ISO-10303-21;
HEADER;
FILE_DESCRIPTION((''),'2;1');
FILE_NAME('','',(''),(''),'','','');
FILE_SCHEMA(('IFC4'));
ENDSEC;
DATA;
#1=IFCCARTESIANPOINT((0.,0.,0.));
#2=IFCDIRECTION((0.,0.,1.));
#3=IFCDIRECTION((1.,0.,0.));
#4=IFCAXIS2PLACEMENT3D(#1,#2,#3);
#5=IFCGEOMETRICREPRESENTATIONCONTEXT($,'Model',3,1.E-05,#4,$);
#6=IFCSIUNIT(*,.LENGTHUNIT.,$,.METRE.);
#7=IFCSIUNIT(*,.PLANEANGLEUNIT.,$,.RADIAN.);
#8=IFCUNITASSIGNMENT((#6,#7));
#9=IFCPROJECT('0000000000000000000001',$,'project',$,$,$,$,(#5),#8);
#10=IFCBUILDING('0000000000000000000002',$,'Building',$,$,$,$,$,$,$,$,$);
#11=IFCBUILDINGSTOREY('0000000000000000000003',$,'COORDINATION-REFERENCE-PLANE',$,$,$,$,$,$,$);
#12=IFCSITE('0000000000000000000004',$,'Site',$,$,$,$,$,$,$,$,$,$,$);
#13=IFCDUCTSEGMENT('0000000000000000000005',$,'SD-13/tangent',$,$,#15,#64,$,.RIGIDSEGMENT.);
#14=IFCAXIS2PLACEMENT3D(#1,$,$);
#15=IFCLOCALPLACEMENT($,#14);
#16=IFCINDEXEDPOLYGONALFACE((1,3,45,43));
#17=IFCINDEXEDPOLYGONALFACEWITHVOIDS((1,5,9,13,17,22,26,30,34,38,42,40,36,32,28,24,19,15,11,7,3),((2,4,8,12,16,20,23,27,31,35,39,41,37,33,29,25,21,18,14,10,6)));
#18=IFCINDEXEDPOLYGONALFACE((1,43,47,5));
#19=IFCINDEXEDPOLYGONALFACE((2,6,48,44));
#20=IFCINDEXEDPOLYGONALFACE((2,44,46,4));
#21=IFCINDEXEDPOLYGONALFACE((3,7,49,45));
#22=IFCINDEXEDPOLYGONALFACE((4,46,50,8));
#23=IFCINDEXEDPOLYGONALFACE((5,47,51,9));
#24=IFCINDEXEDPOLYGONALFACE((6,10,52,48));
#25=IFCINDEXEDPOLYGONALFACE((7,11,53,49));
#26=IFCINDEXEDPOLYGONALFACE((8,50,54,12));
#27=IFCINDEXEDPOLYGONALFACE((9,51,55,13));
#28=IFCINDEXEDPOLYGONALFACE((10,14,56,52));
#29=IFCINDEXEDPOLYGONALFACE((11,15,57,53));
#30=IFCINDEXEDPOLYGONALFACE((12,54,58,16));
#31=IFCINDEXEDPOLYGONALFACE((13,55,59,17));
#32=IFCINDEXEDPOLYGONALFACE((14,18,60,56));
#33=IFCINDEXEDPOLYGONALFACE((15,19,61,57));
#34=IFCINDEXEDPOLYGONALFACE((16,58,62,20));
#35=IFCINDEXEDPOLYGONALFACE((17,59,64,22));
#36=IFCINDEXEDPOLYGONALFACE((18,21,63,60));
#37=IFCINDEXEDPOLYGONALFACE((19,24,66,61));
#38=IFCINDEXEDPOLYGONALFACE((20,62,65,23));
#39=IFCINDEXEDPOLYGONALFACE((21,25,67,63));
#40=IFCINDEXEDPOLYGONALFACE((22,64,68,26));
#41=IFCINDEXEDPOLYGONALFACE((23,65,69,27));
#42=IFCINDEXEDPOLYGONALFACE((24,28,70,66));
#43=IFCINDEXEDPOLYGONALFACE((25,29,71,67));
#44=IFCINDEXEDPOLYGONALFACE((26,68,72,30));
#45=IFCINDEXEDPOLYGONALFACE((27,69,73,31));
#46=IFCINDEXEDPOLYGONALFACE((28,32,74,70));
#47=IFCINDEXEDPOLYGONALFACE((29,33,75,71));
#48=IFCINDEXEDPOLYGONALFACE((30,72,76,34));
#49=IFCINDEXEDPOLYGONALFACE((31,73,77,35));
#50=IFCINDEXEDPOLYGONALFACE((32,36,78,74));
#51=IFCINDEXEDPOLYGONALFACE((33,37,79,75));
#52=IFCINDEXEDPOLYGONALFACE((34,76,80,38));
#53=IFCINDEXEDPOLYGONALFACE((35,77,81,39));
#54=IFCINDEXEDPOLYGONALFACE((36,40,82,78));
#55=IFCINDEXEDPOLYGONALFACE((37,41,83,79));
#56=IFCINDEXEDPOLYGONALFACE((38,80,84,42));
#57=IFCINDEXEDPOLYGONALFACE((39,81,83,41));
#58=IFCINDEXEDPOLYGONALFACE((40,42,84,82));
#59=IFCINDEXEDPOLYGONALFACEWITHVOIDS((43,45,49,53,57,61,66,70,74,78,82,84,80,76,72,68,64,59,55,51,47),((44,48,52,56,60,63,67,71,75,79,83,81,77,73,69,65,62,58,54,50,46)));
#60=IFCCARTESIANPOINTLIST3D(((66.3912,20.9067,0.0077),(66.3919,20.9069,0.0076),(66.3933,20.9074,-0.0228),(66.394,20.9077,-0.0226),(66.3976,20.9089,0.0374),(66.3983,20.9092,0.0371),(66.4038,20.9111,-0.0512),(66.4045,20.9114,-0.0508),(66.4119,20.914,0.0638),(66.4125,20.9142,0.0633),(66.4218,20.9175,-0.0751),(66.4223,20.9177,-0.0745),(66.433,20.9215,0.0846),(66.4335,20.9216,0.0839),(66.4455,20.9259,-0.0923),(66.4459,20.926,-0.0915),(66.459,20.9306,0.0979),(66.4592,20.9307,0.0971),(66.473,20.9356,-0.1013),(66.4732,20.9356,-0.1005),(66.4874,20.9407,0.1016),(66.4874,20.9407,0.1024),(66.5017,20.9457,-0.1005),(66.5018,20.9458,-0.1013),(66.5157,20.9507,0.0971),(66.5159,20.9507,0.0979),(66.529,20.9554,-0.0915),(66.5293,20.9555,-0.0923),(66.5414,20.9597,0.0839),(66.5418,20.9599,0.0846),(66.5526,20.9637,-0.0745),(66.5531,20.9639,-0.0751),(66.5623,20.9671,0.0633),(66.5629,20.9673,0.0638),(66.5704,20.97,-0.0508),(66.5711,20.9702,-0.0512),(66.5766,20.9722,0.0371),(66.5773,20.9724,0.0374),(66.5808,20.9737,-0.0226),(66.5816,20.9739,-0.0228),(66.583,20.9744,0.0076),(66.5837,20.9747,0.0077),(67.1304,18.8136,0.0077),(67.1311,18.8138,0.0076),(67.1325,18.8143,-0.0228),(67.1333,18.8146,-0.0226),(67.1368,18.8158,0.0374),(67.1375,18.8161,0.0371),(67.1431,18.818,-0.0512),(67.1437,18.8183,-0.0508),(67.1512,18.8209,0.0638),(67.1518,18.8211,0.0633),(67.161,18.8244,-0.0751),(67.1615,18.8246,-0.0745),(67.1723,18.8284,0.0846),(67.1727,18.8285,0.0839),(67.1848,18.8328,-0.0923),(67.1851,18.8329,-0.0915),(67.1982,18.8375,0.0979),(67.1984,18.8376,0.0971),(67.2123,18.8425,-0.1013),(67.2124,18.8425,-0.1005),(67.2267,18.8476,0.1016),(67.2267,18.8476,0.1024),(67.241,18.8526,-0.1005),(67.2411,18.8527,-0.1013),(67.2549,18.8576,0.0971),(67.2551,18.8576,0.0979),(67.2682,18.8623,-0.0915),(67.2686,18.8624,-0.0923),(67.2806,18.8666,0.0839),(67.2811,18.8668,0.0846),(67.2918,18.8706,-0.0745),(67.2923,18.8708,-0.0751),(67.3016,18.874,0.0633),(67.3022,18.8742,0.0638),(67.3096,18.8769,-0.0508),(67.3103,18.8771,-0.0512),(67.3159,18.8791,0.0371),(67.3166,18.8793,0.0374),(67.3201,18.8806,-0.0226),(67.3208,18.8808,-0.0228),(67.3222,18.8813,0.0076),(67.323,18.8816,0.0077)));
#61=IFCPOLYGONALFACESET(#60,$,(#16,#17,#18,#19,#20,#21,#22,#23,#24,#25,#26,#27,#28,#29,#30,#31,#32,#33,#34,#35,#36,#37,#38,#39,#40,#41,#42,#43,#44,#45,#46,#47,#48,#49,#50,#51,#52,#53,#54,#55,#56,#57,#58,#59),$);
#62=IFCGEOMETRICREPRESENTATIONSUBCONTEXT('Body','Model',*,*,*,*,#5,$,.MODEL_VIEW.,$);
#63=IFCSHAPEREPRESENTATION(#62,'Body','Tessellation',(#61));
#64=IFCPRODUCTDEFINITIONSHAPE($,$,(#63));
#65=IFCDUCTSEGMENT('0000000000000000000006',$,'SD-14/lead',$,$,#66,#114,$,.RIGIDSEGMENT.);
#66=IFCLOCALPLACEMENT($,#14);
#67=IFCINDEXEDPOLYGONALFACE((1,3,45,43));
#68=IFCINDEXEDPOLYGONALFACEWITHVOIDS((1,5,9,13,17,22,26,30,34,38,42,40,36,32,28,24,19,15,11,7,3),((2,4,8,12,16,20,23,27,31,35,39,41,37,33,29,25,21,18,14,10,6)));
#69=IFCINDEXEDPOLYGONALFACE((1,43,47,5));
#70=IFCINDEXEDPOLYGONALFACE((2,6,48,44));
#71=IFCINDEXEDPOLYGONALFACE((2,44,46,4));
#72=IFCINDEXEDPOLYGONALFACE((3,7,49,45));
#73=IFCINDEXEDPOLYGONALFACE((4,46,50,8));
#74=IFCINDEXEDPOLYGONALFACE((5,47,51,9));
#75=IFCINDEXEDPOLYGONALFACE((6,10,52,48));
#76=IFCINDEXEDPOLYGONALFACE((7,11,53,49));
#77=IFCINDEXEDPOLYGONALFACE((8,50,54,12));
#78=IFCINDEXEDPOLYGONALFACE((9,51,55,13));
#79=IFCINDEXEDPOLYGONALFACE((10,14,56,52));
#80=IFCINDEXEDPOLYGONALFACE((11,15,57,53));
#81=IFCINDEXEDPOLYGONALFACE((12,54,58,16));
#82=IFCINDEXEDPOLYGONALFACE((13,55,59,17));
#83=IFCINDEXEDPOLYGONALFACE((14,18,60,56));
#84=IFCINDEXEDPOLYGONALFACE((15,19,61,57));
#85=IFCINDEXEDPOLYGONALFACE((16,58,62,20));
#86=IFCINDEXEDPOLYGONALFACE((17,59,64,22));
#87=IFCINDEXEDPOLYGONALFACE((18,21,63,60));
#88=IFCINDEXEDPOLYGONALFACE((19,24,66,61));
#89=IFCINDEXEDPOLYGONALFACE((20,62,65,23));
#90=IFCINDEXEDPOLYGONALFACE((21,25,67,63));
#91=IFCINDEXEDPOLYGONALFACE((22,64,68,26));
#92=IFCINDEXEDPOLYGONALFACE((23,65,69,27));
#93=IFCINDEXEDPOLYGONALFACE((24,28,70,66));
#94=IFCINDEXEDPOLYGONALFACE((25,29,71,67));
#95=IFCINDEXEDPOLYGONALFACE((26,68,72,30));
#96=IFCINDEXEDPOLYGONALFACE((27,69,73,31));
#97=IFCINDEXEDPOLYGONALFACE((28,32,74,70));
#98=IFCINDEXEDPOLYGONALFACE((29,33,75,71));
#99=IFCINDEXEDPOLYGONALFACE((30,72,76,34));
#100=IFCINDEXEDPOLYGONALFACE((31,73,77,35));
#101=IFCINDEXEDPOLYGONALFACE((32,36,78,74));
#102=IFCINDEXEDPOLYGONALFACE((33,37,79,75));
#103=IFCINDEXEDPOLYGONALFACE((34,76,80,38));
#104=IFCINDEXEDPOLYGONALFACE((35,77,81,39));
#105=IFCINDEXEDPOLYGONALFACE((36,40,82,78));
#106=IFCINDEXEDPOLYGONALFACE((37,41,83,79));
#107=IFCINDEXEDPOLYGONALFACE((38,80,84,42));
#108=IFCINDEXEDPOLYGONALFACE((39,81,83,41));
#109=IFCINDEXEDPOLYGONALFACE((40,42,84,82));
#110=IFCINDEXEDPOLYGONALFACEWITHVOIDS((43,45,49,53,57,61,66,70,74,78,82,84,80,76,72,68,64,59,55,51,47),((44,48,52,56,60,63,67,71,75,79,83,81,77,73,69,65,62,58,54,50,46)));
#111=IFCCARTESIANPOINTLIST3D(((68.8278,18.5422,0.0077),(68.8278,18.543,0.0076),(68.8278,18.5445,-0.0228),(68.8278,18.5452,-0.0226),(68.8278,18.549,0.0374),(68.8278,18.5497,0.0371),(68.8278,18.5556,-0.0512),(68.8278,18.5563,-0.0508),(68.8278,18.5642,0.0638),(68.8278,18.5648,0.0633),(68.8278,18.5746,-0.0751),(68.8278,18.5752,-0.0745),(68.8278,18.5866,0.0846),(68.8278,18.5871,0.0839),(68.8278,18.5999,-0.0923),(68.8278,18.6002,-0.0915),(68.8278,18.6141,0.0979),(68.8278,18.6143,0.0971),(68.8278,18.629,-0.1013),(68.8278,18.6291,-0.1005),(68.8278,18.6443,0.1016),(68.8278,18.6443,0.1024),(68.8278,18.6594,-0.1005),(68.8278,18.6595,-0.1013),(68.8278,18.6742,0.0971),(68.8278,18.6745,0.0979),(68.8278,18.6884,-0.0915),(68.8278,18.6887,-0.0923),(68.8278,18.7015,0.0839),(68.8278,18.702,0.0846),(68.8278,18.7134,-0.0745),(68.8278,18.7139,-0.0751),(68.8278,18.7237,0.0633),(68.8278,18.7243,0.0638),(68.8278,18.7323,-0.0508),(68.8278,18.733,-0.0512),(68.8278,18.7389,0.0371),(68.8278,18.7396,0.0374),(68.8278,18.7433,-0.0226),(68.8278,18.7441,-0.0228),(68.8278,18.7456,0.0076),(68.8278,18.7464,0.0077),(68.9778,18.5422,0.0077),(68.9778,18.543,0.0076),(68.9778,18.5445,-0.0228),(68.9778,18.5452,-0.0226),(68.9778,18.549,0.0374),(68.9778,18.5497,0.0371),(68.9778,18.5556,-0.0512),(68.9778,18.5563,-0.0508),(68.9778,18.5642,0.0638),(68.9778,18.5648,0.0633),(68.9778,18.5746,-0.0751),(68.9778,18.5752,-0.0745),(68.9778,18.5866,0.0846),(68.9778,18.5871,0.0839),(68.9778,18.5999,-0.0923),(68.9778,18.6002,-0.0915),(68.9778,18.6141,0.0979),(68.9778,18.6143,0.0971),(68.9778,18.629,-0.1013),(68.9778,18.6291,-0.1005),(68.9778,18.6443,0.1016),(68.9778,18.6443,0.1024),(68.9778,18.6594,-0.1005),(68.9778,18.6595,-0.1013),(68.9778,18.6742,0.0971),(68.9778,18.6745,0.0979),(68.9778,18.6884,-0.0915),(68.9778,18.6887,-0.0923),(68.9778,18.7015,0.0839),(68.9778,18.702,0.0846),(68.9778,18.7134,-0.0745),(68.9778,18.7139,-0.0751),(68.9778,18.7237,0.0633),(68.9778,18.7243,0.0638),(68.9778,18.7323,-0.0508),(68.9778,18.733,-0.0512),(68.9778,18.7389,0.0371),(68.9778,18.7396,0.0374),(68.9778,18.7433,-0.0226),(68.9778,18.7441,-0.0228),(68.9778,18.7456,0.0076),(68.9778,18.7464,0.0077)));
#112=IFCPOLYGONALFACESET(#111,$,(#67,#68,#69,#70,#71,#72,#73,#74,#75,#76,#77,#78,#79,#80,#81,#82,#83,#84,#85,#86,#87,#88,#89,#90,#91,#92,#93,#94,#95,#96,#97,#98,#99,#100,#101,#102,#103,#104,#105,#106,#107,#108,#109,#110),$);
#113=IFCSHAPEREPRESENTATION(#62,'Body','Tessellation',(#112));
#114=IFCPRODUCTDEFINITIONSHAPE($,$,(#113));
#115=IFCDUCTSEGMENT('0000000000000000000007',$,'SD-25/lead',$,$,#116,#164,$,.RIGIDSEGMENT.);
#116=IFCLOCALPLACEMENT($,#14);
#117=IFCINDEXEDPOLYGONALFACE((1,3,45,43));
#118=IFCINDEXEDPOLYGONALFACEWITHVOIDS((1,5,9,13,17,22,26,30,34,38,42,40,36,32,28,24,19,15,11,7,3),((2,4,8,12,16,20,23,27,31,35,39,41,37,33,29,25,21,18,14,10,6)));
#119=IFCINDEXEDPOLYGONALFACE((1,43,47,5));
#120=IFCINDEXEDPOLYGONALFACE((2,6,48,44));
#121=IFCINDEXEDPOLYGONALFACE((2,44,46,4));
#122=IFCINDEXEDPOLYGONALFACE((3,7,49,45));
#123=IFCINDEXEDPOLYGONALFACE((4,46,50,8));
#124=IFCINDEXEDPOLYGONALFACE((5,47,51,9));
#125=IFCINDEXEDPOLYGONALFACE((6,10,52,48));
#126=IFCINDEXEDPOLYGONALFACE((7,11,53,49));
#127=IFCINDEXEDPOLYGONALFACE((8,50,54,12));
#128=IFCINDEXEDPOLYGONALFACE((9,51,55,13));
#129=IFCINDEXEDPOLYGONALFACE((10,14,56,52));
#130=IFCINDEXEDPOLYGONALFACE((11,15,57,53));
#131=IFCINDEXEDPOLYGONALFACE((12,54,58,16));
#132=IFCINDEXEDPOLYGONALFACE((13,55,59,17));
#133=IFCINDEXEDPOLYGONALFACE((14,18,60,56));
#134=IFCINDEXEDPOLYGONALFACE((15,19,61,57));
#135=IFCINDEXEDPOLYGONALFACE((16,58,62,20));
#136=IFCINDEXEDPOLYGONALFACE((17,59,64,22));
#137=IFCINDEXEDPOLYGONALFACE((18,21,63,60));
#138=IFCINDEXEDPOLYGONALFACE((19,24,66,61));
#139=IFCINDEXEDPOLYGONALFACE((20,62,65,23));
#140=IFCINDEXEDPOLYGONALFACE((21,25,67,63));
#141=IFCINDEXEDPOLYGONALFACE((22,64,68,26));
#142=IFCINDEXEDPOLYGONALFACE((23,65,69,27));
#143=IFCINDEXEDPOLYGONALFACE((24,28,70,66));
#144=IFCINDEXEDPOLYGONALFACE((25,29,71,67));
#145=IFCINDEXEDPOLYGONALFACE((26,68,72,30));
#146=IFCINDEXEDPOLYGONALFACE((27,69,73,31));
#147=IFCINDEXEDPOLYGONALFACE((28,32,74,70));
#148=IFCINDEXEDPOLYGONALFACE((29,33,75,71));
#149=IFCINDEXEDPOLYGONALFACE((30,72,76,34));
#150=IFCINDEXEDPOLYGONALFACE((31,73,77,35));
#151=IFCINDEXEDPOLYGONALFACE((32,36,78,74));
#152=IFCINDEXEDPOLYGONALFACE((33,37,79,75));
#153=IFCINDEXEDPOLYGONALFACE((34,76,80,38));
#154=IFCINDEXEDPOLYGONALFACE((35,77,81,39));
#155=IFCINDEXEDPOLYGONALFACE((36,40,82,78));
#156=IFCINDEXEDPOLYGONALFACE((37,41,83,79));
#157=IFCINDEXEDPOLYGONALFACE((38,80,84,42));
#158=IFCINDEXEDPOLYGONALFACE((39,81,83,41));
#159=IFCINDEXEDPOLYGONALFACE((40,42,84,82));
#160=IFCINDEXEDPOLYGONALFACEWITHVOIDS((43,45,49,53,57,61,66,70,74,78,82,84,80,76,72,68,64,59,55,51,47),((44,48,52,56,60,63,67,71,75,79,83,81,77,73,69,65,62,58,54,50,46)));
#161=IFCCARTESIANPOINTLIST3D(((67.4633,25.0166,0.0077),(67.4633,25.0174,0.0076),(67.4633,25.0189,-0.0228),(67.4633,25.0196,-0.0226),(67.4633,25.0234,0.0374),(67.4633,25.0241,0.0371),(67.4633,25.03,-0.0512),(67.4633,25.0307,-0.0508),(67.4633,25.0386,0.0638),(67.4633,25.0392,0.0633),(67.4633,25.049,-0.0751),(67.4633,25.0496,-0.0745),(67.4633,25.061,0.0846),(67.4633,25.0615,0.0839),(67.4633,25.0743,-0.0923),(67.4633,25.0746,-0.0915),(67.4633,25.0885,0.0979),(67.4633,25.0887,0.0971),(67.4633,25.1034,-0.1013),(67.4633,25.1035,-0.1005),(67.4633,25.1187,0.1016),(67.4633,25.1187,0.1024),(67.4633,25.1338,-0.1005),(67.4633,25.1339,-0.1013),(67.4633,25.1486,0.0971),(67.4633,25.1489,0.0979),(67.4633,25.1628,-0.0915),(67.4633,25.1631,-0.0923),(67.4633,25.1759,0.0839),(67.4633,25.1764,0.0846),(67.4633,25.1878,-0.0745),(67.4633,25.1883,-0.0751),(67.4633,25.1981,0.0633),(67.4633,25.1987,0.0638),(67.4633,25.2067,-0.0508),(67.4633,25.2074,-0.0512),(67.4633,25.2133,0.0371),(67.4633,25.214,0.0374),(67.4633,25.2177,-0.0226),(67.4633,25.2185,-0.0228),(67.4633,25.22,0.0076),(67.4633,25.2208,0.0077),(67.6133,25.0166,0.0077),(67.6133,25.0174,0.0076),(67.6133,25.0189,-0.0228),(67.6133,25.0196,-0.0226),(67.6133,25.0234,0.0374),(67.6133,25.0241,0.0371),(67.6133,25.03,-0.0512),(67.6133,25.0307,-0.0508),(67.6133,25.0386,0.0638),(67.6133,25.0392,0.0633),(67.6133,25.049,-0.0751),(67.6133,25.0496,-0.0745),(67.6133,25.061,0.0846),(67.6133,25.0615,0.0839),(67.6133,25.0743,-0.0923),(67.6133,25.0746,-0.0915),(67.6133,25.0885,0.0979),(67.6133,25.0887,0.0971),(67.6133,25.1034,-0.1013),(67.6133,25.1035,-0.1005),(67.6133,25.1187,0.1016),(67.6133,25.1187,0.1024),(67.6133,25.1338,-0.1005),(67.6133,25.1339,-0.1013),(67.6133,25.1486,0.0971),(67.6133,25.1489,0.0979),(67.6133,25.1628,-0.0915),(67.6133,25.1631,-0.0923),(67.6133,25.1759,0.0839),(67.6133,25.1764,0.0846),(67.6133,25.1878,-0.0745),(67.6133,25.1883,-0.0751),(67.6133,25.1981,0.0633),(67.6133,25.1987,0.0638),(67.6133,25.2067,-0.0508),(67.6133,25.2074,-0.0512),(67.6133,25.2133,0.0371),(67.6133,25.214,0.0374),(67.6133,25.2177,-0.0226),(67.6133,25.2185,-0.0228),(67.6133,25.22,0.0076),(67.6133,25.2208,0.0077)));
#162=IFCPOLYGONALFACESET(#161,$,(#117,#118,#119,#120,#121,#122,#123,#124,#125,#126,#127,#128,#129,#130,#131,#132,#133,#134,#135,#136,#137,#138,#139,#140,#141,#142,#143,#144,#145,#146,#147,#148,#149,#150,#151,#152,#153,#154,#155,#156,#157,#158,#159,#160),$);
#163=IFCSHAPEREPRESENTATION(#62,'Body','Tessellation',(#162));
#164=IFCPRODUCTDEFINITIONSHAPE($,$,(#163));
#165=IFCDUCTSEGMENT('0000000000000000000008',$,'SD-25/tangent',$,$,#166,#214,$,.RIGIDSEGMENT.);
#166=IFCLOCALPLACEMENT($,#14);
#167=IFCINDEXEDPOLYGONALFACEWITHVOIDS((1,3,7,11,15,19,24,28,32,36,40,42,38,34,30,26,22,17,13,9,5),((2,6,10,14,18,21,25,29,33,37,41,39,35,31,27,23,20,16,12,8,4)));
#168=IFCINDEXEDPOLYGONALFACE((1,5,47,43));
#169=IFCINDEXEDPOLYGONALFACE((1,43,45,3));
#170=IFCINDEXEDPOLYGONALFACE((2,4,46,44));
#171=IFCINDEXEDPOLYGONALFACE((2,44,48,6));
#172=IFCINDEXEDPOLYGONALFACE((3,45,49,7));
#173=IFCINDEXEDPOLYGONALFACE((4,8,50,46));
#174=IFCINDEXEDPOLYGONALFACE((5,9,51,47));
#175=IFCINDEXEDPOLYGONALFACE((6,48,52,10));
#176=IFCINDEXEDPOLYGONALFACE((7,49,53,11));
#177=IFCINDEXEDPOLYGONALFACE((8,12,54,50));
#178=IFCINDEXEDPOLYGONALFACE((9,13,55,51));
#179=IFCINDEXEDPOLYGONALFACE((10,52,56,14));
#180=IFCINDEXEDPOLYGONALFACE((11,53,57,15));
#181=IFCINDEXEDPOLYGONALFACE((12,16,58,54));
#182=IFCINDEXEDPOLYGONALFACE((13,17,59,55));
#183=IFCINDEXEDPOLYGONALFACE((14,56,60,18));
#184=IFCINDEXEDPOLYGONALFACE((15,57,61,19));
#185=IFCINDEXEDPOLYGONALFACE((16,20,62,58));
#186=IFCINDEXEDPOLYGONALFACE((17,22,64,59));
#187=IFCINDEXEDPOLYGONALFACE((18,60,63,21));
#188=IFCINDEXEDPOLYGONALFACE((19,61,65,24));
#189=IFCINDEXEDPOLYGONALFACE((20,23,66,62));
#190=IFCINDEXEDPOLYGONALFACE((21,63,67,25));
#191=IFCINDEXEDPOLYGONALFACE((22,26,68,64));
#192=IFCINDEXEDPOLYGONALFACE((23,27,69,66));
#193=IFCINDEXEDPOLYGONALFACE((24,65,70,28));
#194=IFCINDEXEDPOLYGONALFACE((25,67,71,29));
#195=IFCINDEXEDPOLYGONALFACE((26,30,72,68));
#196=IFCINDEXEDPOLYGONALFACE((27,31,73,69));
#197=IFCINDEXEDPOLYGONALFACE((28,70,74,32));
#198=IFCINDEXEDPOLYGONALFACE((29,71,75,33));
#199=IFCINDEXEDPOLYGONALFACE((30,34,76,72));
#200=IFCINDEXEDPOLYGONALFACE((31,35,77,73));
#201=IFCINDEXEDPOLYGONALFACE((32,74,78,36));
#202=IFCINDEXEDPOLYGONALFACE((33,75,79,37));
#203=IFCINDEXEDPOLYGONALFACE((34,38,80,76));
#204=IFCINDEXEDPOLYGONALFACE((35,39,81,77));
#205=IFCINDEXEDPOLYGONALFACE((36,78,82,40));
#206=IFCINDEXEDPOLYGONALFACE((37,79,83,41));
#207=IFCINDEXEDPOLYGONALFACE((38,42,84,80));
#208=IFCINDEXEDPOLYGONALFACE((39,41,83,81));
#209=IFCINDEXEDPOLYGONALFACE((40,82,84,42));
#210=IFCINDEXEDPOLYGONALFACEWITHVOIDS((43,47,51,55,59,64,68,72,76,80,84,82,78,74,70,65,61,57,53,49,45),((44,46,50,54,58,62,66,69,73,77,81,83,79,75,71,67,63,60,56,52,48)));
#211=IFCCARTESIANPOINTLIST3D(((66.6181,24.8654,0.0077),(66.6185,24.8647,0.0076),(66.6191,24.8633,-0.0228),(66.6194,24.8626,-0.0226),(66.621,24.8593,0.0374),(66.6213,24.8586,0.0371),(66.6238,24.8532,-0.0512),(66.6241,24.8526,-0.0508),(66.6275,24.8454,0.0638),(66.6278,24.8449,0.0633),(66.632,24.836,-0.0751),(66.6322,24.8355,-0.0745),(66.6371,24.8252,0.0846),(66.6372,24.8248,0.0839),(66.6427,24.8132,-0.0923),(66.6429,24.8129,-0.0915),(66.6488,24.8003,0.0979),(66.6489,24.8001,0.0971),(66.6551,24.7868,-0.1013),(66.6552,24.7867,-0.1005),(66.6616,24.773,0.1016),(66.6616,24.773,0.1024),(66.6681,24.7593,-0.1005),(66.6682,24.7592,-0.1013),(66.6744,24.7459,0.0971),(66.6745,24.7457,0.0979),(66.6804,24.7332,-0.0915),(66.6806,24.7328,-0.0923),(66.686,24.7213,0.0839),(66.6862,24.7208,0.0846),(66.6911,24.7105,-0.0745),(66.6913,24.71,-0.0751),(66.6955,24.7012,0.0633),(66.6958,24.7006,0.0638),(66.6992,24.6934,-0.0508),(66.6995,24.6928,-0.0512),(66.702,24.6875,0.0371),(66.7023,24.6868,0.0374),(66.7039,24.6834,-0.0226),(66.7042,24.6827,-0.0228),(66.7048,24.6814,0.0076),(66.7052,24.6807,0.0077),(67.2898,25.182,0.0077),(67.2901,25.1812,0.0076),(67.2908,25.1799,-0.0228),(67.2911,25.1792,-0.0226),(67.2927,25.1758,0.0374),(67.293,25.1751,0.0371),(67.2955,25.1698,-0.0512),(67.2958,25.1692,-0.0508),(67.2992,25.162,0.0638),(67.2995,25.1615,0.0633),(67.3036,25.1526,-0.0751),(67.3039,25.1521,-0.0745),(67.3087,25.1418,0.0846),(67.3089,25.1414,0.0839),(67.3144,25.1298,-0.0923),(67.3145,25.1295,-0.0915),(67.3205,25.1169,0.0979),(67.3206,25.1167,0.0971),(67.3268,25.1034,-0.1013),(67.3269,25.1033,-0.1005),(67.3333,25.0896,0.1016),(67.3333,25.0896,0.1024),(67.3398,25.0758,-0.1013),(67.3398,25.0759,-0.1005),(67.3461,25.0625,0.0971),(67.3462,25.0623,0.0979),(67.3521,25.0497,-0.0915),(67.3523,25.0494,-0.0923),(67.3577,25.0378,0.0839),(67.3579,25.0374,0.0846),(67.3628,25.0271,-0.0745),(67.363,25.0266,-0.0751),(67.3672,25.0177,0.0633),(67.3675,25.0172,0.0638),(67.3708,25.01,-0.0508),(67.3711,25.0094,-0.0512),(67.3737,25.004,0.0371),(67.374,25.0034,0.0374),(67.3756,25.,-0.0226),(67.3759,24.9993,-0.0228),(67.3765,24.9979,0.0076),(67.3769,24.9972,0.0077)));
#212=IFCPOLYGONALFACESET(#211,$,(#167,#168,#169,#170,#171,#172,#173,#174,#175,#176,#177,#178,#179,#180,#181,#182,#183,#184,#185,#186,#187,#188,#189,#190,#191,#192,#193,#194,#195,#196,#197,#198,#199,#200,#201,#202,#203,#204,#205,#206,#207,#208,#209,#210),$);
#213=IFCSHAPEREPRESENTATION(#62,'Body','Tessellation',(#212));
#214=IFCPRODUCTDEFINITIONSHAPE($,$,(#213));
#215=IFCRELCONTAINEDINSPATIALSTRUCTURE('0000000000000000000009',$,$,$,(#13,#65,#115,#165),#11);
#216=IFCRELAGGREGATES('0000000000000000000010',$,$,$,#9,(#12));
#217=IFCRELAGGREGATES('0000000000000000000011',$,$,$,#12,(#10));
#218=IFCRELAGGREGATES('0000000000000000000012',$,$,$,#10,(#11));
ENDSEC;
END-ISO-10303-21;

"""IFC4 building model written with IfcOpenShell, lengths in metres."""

from ifc_helpers import new_model, si_unit, frame, origin_with_axes, place, context, subcontext, project, spatial, hollow_circle, extrude, element, save


model = new_model("IFC4")

# Units and contexts
model_context = context("Model", 3, precision=1e-05, world=origin_with_axes())
body_context_1 = subcontext(model_context, "Body", "Model", "MODEL_VIEW")
ifc_project = project(units=[si_unit("LENGTHUNIT", "METRE"), si_unit("PLANEANGLEUNIT", "RADIAN")], contexts=[model_context])

# Site, building, storey
site = spatial("IfcSite", under=ifc_project, Name="Site")
building = spatial("IfcBuilding", under=site, Name="Building")
storey = spatial("IfcBuildingStorey", under=building, Name="COORDINATION-REFERENCE-PLANE")

# Duct segment
duct_segment_1_placement = place(None, frame((67.2267, 18.8476, 0.0), z_axis=(-0.333018, 0.94292, 0.0), x_axis=(0.0, 0.0, 1.0)))
element("IfcDuctSegment", 1, at=duct_segment_1_placement, inside=storey, Name="SD-13/tangent", PredefinedType="RIGIDSEGMENT", context=body_context_1, shape_type="SweptSolid", body=[
    extrude(hollow_circle(Radius=0.1024, WallThickness=0.0008), origin_with_axes(), (0.0, 0.0, 1.0), 2.2198),
])

# Duct segments
for number, where, z_axis, x_axis, name in (
    (2, (68.8278, 18.6443, 0.0), (1.0, 0.0, 0.0), (0.0, 0.0, 1.0), "SD-14/lead"),
    (3, (67.6133, 25.1187, 0.0), (-1.0, 0.0, 0.0), (0.0, 0.0, 1.0), "SD-25/lead"),
):
    element("IfcDuctSegment", number, at=place(None, frame(where, z_axis=z_axis, x_axis=x_axis)), inside=storey, Name=name, PredefinedType="RIGIDSEGMENT", context=body_context_1, shape_type="SweptSolid", body=[
        extrude(hollow_circle(Radius=0.1024, WallThickness=0.0008), origin_with_axes(), (0.0, 0.0, 1.0), 0.15),
    ])

# Duct segment
duct_segment_2_placement = place(None, frame((67.3333, 25.0896, 0.0), z_axis=(-0.904569, -0.426327, 0.0), x_axis=(0.0, 0.0, 1.0)))
element("IfcDuctSegment", 4, at=duct_segment_2_placement, inside=storey, Name="SD-25/tangent", PredefinedType="RIGIDSEGMENT", context=body_context_1, shape_type="SweptSolid", body=[
    extrude(hollow_circle(Radius=0.1024, WallThickness=0.0008), origin_with_axes(), (0.0, 0.0, 1.0), 0.7425),
])

save(model, "model.ifc")
